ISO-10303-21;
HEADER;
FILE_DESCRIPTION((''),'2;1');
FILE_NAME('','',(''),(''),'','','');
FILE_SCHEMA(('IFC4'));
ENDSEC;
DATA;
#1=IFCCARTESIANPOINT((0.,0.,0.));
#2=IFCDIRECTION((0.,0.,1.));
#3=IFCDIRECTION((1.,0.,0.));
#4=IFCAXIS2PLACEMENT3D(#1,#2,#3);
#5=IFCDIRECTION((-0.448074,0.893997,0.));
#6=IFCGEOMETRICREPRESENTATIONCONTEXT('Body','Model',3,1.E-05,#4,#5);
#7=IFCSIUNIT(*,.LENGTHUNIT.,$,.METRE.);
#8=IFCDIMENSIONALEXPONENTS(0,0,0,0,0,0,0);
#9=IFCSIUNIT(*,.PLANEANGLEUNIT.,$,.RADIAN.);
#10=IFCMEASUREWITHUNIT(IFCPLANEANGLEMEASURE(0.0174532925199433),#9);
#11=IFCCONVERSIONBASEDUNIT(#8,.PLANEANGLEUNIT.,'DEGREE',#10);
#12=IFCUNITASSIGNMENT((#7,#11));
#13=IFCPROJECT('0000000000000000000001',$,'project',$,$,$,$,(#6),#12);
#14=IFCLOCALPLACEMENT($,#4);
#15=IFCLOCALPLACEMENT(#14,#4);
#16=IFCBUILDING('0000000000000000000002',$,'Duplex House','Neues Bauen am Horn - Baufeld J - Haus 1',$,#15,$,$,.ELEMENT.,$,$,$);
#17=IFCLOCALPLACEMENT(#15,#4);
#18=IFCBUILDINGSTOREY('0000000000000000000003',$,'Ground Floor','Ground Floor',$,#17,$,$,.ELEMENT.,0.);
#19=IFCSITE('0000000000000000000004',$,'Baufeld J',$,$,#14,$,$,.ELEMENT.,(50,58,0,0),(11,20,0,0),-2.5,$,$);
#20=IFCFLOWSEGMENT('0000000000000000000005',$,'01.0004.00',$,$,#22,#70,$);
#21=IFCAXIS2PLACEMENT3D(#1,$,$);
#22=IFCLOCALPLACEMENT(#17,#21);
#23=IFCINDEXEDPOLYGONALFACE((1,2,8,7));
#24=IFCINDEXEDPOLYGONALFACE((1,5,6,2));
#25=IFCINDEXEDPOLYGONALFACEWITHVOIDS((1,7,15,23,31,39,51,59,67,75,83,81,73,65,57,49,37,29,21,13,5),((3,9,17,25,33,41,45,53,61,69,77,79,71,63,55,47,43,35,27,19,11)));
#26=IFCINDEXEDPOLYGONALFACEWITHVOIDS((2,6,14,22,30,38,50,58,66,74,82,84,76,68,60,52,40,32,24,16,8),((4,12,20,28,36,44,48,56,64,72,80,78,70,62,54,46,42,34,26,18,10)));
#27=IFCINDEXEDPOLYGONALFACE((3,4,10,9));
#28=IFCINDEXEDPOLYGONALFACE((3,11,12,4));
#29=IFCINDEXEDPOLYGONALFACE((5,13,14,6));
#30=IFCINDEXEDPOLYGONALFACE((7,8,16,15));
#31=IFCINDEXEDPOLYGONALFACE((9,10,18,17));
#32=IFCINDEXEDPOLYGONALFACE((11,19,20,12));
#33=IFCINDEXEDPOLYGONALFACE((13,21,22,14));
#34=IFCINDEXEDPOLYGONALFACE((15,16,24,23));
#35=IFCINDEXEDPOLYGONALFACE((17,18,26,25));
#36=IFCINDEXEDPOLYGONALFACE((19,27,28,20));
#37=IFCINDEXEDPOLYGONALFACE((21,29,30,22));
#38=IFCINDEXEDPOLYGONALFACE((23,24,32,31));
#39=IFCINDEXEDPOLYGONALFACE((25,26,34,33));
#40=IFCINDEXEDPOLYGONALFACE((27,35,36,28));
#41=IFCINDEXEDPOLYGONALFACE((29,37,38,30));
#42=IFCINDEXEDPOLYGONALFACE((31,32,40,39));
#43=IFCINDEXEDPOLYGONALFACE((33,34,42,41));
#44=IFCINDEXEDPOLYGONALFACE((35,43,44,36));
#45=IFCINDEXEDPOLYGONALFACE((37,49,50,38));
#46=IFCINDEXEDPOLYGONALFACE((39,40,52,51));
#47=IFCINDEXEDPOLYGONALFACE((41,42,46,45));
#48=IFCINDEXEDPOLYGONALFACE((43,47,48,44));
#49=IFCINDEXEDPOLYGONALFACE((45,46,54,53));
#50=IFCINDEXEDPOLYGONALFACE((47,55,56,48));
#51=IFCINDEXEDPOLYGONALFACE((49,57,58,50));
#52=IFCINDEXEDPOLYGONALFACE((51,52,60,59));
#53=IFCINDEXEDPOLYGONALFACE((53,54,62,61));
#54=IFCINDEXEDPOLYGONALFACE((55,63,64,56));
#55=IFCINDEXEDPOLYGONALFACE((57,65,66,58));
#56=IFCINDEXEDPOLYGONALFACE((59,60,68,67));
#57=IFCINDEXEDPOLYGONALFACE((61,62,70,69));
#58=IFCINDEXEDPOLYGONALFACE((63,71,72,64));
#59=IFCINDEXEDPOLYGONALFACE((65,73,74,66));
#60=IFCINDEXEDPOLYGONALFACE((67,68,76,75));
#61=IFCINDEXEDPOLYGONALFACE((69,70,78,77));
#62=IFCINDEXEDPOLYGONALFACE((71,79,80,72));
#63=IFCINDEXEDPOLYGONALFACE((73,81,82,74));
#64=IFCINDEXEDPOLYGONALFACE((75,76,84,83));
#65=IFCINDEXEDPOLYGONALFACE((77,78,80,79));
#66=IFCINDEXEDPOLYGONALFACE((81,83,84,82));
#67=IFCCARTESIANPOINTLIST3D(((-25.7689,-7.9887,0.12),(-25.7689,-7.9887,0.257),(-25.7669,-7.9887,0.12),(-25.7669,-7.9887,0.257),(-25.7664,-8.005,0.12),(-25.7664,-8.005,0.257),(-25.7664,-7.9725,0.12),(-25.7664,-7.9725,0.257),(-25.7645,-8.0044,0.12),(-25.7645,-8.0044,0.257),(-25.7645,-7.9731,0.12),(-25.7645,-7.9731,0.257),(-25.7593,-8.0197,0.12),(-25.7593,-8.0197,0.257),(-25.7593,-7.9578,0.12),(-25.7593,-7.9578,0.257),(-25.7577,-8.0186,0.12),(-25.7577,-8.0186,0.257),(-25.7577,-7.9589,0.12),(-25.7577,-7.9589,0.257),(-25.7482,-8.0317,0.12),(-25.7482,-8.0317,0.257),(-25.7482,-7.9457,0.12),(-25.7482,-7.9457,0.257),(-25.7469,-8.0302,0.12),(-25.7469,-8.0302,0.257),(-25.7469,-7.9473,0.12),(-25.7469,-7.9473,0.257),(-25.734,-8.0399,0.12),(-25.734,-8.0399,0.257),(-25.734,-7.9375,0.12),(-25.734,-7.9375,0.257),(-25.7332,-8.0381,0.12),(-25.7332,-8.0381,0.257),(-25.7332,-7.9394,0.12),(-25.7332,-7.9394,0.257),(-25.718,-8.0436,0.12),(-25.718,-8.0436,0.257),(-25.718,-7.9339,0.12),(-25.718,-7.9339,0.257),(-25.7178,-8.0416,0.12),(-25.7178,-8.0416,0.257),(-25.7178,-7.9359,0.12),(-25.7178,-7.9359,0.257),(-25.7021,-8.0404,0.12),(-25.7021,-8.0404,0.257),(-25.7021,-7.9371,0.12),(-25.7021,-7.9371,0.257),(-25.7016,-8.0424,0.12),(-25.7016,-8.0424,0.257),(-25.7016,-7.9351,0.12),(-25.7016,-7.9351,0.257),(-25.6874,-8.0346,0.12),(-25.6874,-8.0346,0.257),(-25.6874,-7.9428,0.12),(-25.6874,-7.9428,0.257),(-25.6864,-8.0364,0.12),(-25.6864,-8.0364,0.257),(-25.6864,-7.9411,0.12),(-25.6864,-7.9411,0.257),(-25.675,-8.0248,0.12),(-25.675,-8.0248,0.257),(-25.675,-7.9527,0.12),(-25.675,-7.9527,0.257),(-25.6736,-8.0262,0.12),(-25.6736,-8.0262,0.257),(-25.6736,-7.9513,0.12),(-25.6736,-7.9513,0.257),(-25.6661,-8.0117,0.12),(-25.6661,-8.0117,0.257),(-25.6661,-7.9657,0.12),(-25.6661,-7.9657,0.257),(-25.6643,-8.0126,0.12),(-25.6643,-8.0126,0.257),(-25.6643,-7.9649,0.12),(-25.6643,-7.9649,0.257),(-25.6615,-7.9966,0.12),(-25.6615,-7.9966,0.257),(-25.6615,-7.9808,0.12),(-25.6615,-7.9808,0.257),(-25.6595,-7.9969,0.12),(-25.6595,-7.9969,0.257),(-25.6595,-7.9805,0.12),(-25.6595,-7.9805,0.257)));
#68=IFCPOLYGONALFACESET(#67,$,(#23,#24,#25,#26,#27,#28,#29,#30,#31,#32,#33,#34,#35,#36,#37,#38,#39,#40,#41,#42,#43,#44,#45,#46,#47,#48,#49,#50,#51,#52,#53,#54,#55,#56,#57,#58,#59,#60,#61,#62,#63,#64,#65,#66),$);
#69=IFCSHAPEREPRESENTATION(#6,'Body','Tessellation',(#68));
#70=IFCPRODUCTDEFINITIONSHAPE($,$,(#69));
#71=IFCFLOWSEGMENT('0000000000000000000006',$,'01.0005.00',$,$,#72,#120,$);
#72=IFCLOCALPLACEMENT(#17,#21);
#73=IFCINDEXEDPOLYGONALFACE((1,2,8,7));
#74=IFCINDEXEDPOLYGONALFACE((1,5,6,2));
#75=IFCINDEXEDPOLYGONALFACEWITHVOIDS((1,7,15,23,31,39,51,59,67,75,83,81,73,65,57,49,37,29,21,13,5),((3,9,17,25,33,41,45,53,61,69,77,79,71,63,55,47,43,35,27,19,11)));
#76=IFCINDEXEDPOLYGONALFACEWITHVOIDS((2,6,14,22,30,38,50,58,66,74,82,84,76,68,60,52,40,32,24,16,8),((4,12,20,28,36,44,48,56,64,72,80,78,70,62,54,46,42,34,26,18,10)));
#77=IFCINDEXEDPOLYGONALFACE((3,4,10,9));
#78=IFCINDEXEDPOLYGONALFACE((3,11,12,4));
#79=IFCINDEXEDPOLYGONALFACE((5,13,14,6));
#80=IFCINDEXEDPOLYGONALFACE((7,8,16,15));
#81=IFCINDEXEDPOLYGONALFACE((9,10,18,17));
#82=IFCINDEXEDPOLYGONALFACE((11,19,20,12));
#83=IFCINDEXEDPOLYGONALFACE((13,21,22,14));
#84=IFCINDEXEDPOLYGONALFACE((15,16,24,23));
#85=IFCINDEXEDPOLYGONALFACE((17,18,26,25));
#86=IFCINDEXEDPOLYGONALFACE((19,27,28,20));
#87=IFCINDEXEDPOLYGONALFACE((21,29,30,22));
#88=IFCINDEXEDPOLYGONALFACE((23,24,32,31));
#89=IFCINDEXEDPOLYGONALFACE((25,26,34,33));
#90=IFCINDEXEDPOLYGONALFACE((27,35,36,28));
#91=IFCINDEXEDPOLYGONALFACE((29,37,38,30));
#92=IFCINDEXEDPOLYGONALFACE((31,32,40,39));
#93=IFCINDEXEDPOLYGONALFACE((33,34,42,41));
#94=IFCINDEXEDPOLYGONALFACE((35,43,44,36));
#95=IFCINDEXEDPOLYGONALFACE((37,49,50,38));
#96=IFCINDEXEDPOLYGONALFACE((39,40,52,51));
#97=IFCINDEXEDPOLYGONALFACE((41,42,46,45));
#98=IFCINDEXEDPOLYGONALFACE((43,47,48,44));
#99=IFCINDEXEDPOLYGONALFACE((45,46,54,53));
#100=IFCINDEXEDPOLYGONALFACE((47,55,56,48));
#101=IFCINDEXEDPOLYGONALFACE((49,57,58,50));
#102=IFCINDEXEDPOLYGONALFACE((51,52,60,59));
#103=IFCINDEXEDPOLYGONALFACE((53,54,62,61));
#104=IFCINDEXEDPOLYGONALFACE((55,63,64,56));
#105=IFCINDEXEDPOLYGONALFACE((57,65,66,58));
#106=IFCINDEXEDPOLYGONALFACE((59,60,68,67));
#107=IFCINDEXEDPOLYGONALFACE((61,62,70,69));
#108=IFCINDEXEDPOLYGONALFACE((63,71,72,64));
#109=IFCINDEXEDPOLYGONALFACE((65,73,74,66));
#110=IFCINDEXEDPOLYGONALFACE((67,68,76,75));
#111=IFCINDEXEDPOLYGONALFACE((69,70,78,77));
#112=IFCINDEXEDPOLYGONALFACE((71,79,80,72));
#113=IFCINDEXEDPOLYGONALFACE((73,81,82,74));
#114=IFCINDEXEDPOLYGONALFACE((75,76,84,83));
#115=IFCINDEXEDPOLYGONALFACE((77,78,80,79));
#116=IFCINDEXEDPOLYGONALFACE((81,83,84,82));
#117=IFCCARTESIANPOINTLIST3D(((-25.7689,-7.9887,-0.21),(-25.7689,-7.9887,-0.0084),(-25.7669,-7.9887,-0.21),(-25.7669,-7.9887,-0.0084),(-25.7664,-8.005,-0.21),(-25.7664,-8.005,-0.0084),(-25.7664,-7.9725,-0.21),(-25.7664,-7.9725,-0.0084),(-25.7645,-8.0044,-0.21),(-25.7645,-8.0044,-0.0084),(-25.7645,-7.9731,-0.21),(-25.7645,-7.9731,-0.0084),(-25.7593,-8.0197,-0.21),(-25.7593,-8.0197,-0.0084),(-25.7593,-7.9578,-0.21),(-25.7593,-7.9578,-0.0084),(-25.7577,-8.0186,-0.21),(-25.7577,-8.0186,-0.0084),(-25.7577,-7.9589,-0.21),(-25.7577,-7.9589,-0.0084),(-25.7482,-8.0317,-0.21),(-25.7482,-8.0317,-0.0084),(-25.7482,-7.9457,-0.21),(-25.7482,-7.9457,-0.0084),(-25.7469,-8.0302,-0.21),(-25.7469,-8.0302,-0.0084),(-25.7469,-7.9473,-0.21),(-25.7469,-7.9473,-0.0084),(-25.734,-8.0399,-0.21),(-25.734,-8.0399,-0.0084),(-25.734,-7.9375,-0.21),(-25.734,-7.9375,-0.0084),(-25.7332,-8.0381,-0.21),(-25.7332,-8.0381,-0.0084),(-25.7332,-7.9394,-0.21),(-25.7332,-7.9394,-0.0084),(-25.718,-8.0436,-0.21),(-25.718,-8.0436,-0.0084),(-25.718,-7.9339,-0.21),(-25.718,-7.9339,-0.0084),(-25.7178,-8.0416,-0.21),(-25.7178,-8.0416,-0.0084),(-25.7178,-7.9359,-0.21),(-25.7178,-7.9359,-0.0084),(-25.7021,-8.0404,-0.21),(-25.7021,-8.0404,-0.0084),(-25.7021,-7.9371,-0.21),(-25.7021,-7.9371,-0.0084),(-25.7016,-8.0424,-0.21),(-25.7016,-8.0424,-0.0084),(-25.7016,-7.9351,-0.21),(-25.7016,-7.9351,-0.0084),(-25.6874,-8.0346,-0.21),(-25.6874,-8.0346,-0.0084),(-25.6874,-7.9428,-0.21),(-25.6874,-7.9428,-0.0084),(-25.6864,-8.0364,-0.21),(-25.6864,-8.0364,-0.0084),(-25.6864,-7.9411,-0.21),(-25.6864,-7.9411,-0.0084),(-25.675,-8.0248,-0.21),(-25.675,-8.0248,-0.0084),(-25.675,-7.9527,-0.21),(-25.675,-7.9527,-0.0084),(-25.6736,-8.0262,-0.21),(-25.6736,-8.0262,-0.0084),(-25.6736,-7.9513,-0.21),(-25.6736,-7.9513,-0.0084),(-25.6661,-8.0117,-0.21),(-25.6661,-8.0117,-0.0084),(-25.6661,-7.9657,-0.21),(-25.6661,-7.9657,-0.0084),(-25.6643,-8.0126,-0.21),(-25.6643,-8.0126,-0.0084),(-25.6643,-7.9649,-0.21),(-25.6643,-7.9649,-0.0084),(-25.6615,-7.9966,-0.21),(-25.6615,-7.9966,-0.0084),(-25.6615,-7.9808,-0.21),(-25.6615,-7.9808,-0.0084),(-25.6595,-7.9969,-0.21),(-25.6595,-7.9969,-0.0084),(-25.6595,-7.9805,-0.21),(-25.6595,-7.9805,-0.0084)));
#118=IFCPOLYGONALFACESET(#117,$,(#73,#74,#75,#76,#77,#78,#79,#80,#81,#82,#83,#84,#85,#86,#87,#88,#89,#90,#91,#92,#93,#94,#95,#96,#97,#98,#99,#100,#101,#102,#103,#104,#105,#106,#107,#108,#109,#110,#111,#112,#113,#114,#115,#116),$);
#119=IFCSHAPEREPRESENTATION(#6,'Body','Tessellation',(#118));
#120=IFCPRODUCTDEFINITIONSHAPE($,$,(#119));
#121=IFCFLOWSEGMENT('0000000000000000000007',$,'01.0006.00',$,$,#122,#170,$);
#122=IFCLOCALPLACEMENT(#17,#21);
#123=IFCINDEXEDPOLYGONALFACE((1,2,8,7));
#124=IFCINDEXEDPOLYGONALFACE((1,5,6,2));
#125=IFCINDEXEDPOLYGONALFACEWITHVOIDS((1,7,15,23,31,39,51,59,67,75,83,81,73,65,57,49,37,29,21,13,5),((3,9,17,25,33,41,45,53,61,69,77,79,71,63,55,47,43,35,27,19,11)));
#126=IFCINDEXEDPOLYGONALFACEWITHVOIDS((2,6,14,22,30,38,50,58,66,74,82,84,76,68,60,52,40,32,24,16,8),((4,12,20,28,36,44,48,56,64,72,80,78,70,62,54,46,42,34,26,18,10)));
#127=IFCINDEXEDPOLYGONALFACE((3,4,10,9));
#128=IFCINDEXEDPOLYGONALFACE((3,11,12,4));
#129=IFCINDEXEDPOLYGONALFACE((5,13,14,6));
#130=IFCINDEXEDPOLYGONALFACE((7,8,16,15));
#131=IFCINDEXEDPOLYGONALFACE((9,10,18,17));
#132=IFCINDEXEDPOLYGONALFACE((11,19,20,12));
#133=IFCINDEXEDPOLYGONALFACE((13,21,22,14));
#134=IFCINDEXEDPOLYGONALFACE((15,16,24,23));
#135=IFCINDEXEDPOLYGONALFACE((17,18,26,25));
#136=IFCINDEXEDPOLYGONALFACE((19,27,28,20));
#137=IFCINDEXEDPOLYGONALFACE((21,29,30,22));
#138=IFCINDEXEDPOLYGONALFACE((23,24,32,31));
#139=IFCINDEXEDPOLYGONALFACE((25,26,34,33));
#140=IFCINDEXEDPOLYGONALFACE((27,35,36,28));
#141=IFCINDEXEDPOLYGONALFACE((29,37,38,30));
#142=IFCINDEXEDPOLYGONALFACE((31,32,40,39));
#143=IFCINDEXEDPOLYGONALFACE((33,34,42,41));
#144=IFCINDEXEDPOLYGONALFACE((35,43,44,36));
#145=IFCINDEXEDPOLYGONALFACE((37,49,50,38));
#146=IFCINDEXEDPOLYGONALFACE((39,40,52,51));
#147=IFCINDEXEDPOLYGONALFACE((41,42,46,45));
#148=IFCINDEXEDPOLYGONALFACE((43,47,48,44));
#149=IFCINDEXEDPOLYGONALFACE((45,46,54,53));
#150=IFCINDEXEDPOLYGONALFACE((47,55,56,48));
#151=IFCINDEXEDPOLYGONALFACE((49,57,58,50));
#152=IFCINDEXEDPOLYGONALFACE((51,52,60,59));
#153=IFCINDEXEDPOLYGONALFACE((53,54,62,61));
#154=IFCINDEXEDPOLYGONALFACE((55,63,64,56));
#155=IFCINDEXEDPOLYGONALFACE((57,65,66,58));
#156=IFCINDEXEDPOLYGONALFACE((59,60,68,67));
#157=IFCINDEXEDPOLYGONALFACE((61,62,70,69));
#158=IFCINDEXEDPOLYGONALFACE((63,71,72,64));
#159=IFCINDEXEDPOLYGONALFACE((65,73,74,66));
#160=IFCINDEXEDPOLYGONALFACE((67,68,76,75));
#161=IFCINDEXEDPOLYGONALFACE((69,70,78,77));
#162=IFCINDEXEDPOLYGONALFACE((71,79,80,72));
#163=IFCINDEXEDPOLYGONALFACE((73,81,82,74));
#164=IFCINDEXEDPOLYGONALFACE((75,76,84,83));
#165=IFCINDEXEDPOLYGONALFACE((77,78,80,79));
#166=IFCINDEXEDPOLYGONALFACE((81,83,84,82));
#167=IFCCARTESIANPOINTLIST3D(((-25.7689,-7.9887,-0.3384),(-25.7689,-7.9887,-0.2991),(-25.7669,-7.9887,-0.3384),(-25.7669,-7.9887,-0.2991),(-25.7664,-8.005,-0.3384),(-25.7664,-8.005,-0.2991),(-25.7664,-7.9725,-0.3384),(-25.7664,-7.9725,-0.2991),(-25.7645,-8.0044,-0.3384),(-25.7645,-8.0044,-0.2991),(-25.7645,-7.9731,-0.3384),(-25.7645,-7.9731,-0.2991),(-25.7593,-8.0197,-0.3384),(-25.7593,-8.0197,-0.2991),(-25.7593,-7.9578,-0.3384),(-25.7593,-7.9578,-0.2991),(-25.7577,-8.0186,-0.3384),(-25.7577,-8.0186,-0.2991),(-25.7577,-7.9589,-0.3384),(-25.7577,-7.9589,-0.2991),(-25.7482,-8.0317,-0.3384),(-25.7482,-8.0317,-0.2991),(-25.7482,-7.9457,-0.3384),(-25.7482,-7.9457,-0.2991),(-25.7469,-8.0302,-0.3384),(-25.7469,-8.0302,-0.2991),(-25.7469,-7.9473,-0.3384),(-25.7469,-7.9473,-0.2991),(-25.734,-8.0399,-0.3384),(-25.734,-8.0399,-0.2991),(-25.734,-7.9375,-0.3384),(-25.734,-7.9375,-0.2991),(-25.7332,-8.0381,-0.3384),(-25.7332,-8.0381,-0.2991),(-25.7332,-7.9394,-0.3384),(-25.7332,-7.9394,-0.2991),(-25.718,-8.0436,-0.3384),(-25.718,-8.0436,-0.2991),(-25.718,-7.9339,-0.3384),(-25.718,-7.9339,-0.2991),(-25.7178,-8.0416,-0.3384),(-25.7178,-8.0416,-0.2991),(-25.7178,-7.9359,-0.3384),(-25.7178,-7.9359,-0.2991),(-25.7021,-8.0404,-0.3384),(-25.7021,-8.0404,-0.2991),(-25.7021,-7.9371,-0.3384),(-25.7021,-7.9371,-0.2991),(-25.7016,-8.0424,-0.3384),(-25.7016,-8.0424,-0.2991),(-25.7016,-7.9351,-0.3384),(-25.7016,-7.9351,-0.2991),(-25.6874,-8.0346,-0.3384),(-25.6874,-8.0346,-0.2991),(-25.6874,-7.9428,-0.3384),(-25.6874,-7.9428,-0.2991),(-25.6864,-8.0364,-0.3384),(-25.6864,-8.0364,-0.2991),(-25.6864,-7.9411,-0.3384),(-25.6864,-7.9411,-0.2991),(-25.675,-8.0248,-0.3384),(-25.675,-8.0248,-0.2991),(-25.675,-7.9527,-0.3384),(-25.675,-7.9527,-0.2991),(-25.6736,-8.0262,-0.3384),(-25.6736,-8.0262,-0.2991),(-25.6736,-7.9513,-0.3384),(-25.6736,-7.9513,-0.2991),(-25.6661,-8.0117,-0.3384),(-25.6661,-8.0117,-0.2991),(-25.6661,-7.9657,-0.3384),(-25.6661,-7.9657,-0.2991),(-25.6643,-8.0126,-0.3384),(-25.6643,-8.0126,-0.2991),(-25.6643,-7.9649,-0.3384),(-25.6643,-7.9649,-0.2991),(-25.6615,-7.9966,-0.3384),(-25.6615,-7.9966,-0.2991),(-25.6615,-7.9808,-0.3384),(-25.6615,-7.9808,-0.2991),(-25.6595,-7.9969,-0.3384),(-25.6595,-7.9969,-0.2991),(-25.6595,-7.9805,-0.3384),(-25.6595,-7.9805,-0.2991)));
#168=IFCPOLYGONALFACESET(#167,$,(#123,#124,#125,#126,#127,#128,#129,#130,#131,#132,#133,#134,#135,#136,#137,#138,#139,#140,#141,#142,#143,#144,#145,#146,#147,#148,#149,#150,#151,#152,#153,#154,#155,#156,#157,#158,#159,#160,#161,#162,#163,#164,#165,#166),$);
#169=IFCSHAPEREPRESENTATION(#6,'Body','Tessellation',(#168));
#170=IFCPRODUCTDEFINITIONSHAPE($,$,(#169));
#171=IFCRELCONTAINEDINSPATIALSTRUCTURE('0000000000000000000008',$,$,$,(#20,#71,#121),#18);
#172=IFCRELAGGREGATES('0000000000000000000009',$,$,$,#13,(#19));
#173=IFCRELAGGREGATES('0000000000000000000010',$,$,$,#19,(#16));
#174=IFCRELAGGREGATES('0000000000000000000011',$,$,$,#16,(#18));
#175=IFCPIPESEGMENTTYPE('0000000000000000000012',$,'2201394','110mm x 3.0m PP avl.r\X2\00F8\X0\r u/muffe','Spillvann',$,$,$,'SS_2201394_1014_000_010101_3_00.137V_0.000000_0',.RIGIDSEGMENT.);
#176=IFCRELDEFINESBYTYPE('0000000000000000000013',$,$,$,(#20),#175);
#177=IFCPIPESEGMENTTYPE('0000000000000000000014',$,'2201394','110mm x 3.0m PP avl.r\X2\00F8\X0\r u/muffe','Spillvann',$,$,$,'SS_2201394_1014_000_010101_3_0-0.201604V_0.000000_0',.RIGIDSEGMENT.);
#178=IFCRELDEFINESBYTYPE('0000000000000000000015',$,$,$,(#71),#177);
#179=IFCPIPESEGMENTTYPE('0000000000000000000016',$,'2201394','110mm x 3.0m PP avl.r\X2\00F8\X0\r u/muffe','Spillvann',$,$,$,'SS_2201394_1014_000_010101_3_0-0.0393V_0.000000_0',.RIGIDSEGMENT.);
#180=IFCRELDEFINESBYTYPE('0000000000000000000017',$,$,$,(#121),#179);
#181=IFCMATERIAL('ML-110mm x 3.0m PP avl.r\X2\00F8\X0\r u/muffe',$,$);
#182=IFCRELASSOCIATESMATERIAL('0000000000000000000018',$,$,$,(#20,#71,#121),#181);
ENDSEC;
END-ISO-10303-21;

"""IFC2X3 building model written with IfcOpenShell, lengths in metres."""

from ifc_helpers import new_model, entity, si_unit, converted_unit, direction, frame, origin_with_axes, origin_2d_with_axis, place, context, project, spatial, hollow_circle, extrude, material, type_object, element, save


model = new_model("IFC2X3")

# Units and contexts
model_context = context("Model", 3, precision=1e-05, world=origin_with_axes(), true_north=direction((-0.448074, 0.893997, 0.0)), identifier="Body")
ifc_project = project(units=[si_unit("LENGTHUNIT", "METRE"), converted_unit("PLANEANGLEUNIT", "DEGREE", entity("IfcPlaneAngleMeasure", 0.0174532925199433), si_unit("PLANEANGLEUNIT", "RADIAN"), dimensions=[0, 0, 0, 0, 0, 0, 0])], contexts=[model_context])

# Site, building, storey
site_placement = place(None, origin_with_axes())
site = spatial("IfcSite", under=ifc_project, at=site_placement, Name="Baufeld J", CompositionType="ELEMENT", RefLatitude=(50, 58, 0, 0), RefLongitude=(11, 20, 0, 0), RefElevation=-2.5)
building_placement = place(site_placement, origin_with_axes())
building = spatial("IfcBuilding", under=site, at=building_placement, Name="Duplex House", Description="Neues Bauen am Horn - Baufeld J - Haus 1", CompositionType="ELEMENT")
storey_placement = place(building_placement, origin_with_axes())
storey = spatial("IfcBuildingStorey", under=building, at=storey_placement, Name="Ground Floor", Description="Ground Floor", CompositionType="ELEMENT", Elevation=0.0)

# Flow segments
ifc_material_1 = material(Name="ML-110mm x 3.0m PP avl.rør u/muffe")
pipe_segment_type_1 = type_object("IfcPipeSegmentType", Name="2201394", Description="110mm x 3.0m PP avl.rør u/muffe", ApplicableOccurrence="Spillvann", ElementType="SS_2201394_1014_000_010101_3_00.137V_0.000000_0", PredefinedType="RIGIDSEGMENT")
flow_segment_1_placement = place(storey_placement, frame((-25.7139, -7.9887, 0.257), z_axis=(1.0, 0.0, 0.0), x_axis=(0.0, 0.0, -1.0)))
element("IfcFlowSegment", 1, at=flow_segment_1_placement, inside=storey, type_object=pipe_segment_type_1, material=ifc_material_1, Name="01.0004.00", context=model_context, shape_type="SweptSolid", body=[
    extrude(hollow_circle(Radius=0.055, WallThickness=0.002, at=origin_2d_with_axis()), frame((0.0, 0.0, 0.0), z_axis=(1.0, 0.0, 0.0), x_axis=(0.0, 0.0, -1.0)), (0.0, 0.0, 1.0), 0.137),
])
pipe_segment_type_2 = type_object("IfcPipeSegmentType", Name="2201394", Description="110mm x 3.0m PP avl.rør u/muffe", ApplicableOccurrence="Spillvann", ElementType="SS_2201394_1014_000_010101_3_0-0.201604V_0.000000_0", PredefinedType="RIGIDSEGMENT")
flow_segment_2_placement = place(storey_placement, frame((-25.7139, -7.9887, -0.21), z_axis=(1.0, 0.0, 0.0), x_axis=(0.0, 0.0, -1.0)))
element("IfcFlowSegment", 2, at=flow_segment_2_placement, inside=storey, type_object=pipe_segment_type_2, material=ifc_material_1, Name="01.0005.00", context=model_context, shape_type="SweptSolid", body=[
    extrude(hollow_circle(Radius=0.055, WallThickness=0.002, at=origin_2d_with_axis()), frame((0.0, 0.0, 0.0), z_axis=(1.0, 0.0, 0.0), x_axis=(0.0, 0.0, -1.0)), (0.0, 0.0, -1.0), 0.2016),
])
pipe_segment_type_3 = type_object("IfcPipeSegmentType", Name="2201394", Description="110mm x 3.0m PP avl.rør u/muffe", ApplicableOccurrence="Spillvann", ElementType="SS_2201394_1014_000_010101_3_0-0.0393V_0.000000_0", PredefinedType="RIGIDSEGMENT")
flow_segment_3_placement = place(storey_placement, frame((-25.7139, -7.9887, -0.3384), z_axis=(1.0, 0.0, 0.0), x_axis=(0.0, 0.0, -1.0)))
element("IfcFlowSegment", 3, at=flow_segment_3_placement, inside=storey, type_object=pipe_segment_type_3, material=ifc_material_1, Name="01.0006.00", context=model_context, shape_type="SweptSolid", body=[
    extrude(hollow_circle(Radius=0.055, WallThickness=0.002, at=origin_2d_with_axis()), frame((0.0, 0.0, 0.0), z_axis=(1.0, 0.0, 0.0), x_axis=(0.0, 0.0, -1.0)), (0.0, 0.0, -1.0), 0.0393),
])

save(model, "model.ifc")
